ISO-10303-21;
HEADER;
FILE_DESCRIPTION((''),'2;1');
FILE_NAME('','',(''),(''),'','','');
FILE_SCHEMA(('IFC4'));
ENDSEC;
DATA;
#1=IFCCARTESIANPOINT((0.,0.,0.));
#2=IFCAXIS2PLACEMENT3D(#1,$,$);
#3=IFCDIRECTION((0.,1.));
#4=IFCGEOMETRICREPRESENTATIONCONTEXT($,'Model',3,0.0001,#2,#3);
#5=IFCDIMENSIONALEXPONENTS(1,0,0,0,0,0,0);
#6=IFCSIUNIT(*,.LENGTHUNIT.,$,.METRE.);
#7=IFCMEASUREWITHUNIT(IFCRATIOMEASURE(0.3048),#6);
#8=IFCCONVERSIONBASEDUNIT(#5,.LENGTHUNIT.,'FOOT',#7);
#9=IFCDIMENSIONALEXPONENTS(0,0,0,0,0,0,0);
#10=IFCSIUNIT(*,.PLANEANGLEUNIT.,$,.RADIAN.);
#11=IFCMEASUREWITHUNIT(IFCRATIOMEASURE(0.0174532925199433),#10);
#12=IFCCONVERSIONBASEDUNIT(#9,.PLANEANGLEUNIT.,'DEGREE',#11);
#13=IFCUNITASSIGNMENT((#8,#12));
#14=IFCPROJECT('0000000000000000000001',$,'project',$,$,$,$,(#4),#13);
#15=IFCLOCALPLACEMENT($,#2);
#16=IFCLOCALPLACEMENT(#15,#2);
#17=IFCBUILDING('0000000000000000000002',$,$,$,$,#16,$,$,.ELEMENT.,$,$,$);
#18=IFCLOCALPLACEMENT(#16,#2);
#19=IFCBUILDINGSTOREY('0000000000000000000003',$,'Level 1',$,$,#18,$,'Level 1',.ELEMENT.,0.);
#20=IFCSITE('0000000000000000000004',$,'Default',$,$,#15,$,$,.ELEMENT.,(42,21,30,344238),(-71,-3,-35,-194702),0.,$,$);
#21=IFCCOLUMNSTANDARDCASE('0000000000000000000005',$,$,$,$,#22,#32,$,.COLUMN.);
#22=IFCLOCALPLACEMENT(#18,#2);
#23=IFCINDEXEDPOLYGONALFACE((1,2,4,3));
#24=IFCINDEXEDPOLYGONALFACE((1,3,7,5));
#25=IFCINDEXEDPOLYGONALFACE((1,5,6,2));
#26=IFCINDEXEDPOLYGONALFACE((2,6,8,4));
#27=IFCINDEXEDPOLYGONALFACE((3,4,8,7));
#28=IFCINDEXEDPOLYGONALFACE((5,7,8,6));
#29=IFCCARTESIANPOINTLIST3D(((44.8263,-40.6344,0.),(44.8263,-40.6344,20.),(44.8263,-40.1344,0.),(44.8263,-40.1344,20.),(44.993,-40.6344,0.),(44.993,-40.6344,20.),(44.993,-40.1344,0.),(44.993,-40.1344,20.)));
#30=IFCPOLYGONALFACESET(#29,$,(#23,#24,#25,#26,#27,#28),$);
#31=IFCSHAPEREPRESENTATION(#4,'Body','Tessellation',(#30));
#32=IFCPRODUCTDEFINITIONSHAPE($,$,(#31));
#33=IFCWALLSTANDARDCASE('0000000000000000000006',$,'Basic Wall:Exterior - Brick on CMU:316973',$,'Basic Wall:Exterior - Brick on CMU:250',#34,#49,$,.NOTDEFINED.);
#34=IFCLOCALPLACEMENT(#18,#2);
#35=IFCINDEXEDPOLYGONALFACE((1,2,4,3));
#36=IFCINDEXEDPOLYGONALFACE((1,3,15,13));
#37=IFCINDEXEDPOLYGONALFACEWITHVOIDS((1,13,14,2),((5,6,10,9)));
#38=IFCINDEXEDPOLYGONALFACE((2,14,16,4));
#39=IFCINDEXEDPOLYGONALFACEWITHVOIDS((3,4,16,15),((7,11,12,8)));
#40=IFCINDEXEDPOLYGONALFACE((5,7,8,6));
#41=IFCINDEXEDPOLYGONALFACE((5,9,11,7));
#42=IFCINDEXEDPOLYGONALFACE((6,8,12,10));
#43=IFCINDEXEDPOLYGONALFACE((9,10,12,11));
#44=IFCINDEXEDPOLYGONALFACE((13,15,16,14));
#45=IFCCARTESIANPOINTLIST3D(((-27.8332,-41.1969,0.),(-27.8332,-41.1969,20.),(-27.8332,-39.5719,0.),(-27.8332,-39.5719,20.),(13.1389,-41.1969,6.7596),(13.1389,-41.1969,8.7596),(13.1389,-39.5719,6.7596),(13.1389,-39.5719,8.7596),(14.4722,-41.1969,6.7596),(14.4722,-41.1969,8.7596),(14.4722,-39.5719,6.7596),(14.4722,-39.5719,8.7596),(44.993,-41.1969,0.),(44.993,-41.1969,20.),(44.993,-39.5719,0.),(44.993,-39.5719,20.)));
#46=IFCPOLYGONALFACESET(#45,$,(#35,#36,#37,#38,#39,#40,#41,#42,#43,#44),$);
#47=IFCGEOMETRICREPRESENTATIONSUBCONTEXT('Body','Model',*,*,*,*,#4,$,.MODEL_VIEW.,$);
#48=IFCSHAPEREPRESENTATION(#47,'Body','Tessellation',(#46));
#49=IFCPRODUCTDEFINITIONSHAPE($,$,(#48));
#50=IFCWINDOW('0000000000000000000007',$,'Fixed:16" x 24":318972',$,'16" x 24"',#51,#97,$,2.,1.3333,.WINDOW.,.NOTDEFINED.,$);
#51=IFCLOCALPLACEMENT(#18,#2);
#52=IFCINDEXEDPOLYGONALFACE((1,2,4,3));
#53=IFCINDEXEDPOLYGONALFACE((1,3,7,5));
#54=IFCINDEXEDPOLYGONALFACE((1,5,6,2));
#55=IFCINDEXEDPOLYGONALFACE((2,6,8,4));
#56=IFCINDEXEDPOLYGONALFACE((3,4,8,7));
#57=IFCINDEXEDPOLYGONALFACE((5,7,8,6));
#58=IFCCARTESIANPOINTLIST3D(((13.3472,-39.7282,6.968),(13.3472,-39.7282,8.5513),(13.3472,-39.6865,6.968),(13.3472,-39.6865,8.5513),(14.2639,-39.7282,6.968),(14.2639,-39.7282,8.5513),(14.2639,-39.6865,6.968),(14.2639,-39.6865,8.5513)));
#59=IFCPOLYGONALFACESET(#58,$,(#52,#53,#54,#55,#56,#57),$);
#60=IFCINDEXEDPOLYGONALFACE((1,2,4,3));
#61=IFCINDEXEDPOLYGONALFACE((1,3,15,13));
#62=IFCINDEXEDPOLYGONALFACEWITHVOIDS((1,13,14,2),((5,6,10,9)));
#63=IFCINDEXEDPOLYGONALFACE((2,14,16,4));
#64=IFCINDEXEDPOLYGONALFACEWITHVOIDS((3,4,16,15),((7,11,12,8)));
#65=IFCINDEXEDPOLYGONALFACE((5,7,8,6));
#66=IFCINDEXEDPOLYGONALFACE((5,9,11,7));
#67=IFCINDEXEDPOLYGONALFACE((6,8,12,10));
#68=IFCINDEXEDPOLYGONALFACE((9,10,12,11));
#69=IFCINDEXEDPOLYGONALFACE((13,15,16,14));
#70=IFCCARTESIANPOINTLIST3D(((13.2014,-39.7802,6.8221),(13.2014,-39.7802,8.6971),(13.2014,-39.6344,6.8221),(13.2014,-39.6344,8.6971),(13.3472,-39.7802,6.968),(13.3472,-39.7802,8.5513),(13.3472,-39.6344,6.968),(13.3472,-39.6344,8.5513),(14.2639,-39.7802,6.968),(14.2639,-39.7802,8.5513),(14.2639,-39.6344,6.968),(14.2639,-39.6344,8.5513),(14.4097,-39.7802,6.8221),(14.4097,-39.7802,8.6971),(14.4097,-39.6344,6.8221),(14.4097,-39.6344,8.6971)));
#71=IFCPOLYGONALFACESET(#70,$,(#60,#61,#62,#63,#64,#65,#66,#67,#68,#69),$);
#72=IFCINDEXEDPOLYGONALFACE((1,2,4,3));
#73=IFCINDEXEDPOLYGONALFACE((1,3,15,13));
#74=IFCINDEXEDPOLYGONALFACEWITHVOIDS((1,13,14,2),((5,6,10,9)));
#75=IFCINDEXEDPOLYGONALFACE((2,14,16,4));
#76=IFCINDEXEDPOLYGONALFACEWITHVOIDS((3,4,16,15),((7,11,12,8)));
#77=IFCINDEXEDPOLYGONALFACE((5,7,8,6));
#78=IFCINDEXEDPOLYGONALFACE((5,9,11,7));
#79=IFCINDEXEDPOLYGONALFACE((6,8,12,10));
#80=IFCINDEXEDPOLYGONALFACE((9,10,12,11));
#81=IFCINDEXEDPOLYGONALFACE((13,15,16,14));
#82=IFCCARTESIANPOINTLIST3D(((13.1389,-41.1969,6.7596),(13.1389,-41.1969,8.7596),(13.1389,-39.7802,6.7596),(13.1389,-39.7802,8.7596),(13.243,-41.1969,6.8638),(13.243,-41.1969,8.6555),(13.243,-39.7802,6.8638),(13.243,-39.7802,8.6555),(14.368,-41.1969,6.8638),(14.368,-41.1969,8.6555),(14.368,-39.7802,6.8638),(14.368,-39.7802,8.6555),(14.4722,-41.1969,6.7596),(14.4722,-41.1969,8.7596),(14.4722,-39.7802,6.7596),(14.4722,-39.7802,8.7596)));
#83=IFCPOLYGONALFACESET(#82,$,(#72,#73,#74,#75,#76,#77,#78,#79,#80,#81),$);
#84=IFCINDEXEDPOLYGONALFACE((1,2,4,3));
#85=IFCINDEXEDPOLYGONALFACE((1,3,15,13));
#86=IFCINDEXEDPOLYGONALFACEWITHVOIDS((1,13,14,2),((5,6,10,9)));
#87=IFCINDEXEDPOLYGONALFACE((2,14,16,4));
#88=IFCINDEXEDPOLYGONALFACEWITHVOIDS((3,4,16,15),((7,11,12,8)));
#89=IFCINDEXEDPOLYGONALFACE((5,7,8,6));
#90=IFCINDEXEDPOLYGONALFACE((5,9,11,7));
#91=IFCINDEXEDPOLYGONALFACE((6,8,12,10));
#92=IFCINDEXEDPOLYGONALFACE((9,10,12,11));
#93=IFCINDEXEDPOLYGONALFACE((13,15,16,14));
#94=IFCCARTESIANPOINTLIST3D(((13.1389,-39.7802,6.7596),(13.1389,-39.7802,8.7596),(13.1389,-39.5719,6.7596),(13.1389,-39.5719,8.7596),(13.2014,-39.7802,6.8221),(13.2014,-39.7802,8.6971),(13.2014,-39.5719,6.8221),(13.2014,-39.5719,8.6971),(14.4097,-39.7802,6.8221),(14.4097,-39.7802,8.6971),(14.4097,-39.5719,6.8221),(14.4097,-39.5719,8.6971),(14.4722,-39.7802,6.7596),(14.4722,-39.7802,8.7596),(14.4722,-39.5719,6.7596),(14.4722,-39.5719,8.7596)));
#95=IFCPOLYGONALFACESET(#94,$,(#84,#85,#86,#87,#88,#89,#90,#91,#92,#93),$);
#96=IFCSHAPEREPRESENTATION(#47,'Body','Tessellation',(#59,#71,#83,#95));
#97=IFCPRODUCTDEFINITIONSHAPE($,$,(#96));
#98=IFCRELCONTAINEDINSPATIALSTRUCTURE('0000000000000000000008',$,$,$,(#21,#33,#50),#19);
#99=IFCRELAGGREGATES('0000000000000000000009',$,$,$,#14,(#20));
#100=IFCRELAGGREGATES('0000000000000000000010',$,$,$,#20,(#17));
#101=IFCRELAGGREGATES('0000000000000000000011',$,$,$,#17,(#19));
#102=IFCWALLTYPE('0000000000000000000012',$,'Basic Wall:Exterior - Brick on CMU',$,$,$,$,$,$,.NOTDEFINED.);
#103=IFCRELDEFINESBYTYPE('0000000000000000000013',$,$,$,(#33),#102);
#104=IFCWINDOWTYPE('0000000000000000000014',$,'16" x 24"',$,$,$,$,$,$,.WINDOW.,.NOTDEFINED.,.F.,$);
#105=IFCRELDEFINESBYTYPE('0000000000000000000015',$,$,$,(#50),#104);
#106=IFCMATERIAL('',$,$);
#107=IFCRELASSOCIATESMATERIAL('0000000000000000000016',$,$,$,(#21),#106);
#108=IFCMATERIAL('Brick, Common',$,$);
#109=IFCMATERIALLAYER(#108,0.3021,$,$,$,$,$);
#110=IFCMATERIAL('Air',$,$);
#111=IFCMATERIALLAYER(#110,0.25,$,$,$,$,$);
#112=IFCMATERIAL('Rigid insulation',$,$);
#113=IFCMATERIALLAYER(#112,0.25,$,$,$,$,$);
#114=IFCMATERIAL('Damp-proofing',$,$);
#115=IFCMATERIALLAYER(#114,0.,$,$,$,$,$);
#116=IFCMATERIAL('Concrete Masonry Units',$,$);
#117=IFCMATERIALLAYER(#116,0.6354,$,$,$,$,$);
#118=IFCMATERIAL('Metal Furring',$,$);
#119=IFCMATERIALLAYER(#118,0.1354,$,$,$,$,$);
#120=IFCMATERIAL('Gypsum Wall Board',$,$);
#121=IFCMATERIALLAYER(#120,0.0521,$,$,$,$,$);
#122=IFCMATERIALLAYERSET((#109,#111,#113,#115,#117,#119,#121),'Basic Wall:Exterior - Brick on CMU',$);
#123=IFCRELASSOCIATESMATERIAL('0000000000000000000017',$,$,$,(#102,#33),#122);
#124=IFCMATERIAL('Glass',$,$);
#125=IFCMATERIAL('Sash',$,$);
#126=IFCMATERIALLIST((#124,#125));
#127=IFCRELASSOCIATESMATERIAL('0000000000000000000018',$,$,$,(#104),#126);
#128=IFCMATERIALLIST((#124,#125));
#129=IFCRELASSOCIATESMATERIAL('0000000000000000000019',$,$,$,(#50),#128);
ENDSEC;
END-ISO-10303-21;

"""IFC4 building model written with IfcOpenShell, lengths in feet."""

from ifc_helpers import new_model, entity, si_unit, converted_unit, direction, frame, frame_2d, origin, place, context, subcontext, project, spatial, polyline, rectangle, outline, extrude, source, transform, mapped, material, material_list, layer, layer_set, layer_usage, type_object, type_shapes, element, fill, save


model = new_model("IFC4")

# Units and contexts
model_context = context("Model", 3, precision=0.0001, world=origin(), true_north=direction((0.0, 1.0)))
body_context = subcontext(model_context, "Body", "Model", "MODEL_VIEW")
ifc_project = project(units=[converted_unit("LENGTHUNIT", "FOOT", entity("IfcRatioMeasure", 0.3048), si_unit("LENGTHUNIT", "METRE"), dimensions=[1, 0, 0, 0, 0, 0, 0]), converted_unit("PLANEANGLEUNIT", "DEGREE", entity("IfcRatioMeasure", 0.0174532925199433), si_unit("PLANEANGLEUNIT", "RADIAN"), dimensions=[0, 0, 0, 0, 0, 0, 0])], contexts=[model_context])

# Site, building, storey
site_placement = place(None, origin())
site = spatial("IfcSite", under=ifc_project, at=site_placement, Name="Default", CompositionType="ELEMENT", RefLatitude=(42, 21, 30, 344238), RefLongitude=(-71, -3, -35, -194702), RefElevation=0.0)
building_placement = place(site_placement, origin())
building = spatial("IfcBuilding", under=site, at=building_placement, CompositionType="ELEMENT")
storey_placement = place(building_placement, origin())
storey = spatial("IfcBuildingStorey", under=building, at=storey_placement, Name="Level 1", LongName="Level 1", CompositionType="ELEMENT", Elevation=0.0)

# Column
ifc_material_1 = material(Name="")
wall_placement = place(storey_placement, frame((44.993, -40.3844, 0.0), z_axis=(0.0, 0.0, 1.0), x_axis=(-1.0, 0.0, 0.0)))
for number, where, z_axis, x_axis in (
    (1, (0.0833, 0.0, 0.0), (0.0, 0.0, 1.0), (1.0, 0.0, 0.0)),
):
    element("IfcColumnStandardCase", number, at=place(wall_placement, frame(where, z_axis=z_axis, x_axis=x_axis)), inside=storey, material=ifc_material_1, PredefinedType="COLUMN", context=model_context, shape_type="SweptSolid", body=[
        extrude(rectangle(XDim=0.1667, YDim=0.5), origin(), (0.0, 0.0, 1.0), 20.0),
    ])

# Wall, opening, window
ifc_material_2 = material(Name="Brick, Common")
ifc_layer_1 = layer(ifc_material_2, 0.3021)
ifc_material_3 = material(Name="Air")
ifc_layer_2 = layer(ifc_material_3, 0.25)
ifc_material_4 = material(Name="Rigid insulation")
ifc_layer_3 = layer(ifc_material_4, 0.25)
ifc_material_5 = material(Name="Damp-proofing")
ifc_layer_4 = layer(ifc_material_5, 0.0)
ifc_material_6 = material(Name="Concrete Masonry Units")
ifc_layer_5 = layer(ifc_material_6, 0.6354)
ifc_material_7 = material(Name="Metal Furring")
ifc_layer_6 = layer(ifc_material_7, 0.1354)
ifc_material_8 = material(Name="Gypsum Wall Board")
ifc_layer_7 = layer(ifc_material_8, 0.0521)
ifc_layer_set = layer_set([ifc_layer_1, ifc_layer_2, ifc_layer_3, ifc_layer_4, ifc_layer_5, ifc_layer_6, ifc_layer_7], Name="Basic Wall:Exterior - Brick on CMU")
ifc_layer_usage = layer_usage(ifc_layer_set, "AXIS2", "NEGATIVE", 0.8125)
wall_type = type_object("IfcWallType", Name="Basic Wall:Exterior - Brick on CMU", PredefinedType="NOTDEFINED", material=ifc_layer_set)
wall = element("IfcWallStandardCase", 2, at=wall_placement, inside=storey, type_object=wall_type, material=ifc_layer_usage, Name="Basic Wall:Exterior - Brick on CMU:316973", ObjectType="Basic Wall:Exterior - Brick on CMU:250", PredefinedType="NOTDEFINED", context=body_context, shape_type="SweptSolid", body=[
    extrude(rectangle(XDim=72.8262, YDim=1.625, at=frame_2d((36.4131, 0.0), x_axis=(-1.0, 0.0))), origin(), (0.0, 0.0, 1.0), 20.0),
])
opening_placement = place(wall_placement, frame((31.8542, 0.8125, 6.7596)))
opening = element("IfcOpeningElement", 3, at=opening_placement, cuts=wall, ObjectType="Opening", PredefinedType="OPENING", context=body_context, shape_type="SweptSolid", body=[
    extrude(rectangle(XDim=2.0, YDim=1.3333, at=frame_2d((1.0, 0.6667), x_axis=(-1.0, 0.0))), frame((0.0, 0.0, 0.0), z_axis=(0.0, -1.0, 0.0), x_axis=(0.0, 0.0, 1.0)), (0.0, 0.0, 1.0), 1.625),
])
ifc_material_9 = material(Name="Glass")
ifc_material_10 = material(Name="Sash")
ifc_material_list_1 = material_list([ifc_material_9, ifc_material_10])
ifc_material_list_2 = material_list([ifc_material_9, ifc_material_10])
window_type = type_object("IfcWindowType", Name="16\" x 24\"", ParameterTakesPrecedence=False, PartitioningType="NOTDEFINED", PredefinedType="WINDOW", material=ifc_material_list_2)
shared_shape = source(origin(), body_context, "Body", "SweptSolid", [
    extrude(rectangle(XDim=0.0417, YDim=0.9167, at=frame_2d((0.0, 0.0), x_axis=(1.0, 0.0))), frame((0.6667, 1.4896, 0.2083), z_axis=(0.0, 0.0, 1.0), x_axis=(0.0, 1.0, 0.0)), (0.0, 0.0, 1.0), 1.5833),
    extrude(outline(polyline([(-0.6042, -0.9375), (0.6042, -0.9375), (0.6042, 0.9375), (-0.6042, 0.9375), (-0.6042, -0.9375)]), holes=[polyline([(-0.4583, -0.7917), (-0.4583, 0.7917), (0.4583, 0.7917), (0.4583, -0.7917), (-0.4583, -0.7917)])]), frame((0.6667, 1.4167, 1.0), z_axis=(0.0, 1.0, 0.0), x_axis=(1.0, 0.0, 0.0)), (0.0, 0.0, 1.0), 0.1458),
    extrude(outline(polyline([(-0.6667, -1.0), (0.6667, -1.0), (0.6667, 1.0), (-0.6667, 1.0), (-0.6667, -1.0)]), holes=[polyline([(-0.5625, -0.8958), (-0.5625, 0.8958), (0.5625, 0.8958), (0.5625, -0.8958), (-0.5625, -0.8958)])]), frame((0.6667, 0.0, 1.0), z_axis=(0.0, 1.0, 0.0), x_axis=(1.0, 0.0, 0.0)), (0.0, 0.0, 1.0), 1.4167),
    extrude(outline(polyline([(-1.0, -0.6667), (1.0, -0.6667), (1.0, 0.6667), (-1.0, 0.6667), (-1.0, -0.6667)]), holes=[polyline([(-0.9375, -0.6042), (-0.9375, 0.6042), (0.9375, 0.6042), (0.9375, -0.6042), (-0.9375, -0.6042)])]), frame((0.6667, 1.4167, 1.0), z_axis=(0.0, 1.0, 0.0), x_axis=(0.0, 0.0, -1.0)), (0.0, 0.0, 1.0), 0.2083),
])
type_shapes(window_type, [shared_shape])
window_placement = place(opening_placement, frame((0.0, 0.0, 0.0), z_axis=(0.0, 0.0, 1.0), x_axis=(-1.0, 0.0, 0.0)))
window = element("IfcWindow", 4, at=window_placement, inside=storey, type_object=window_type, material=ifc_material_list_1, Name="Fixed:16\" x 24\":318972", ObjectType="16\" x 24\"", OverallHeight=2.0, OverallWidth=1.3333, PartitioningType="NOTDEFINED", PredefinedType="WINDOW", context=body_context, shape_type="MappedRepresentation", body=[
    mapped(shared_shape, transform((0.0, 0.0, 0.0), scale=1.0)),
])
fill(opening, window)

save(model, "model.ifc")
